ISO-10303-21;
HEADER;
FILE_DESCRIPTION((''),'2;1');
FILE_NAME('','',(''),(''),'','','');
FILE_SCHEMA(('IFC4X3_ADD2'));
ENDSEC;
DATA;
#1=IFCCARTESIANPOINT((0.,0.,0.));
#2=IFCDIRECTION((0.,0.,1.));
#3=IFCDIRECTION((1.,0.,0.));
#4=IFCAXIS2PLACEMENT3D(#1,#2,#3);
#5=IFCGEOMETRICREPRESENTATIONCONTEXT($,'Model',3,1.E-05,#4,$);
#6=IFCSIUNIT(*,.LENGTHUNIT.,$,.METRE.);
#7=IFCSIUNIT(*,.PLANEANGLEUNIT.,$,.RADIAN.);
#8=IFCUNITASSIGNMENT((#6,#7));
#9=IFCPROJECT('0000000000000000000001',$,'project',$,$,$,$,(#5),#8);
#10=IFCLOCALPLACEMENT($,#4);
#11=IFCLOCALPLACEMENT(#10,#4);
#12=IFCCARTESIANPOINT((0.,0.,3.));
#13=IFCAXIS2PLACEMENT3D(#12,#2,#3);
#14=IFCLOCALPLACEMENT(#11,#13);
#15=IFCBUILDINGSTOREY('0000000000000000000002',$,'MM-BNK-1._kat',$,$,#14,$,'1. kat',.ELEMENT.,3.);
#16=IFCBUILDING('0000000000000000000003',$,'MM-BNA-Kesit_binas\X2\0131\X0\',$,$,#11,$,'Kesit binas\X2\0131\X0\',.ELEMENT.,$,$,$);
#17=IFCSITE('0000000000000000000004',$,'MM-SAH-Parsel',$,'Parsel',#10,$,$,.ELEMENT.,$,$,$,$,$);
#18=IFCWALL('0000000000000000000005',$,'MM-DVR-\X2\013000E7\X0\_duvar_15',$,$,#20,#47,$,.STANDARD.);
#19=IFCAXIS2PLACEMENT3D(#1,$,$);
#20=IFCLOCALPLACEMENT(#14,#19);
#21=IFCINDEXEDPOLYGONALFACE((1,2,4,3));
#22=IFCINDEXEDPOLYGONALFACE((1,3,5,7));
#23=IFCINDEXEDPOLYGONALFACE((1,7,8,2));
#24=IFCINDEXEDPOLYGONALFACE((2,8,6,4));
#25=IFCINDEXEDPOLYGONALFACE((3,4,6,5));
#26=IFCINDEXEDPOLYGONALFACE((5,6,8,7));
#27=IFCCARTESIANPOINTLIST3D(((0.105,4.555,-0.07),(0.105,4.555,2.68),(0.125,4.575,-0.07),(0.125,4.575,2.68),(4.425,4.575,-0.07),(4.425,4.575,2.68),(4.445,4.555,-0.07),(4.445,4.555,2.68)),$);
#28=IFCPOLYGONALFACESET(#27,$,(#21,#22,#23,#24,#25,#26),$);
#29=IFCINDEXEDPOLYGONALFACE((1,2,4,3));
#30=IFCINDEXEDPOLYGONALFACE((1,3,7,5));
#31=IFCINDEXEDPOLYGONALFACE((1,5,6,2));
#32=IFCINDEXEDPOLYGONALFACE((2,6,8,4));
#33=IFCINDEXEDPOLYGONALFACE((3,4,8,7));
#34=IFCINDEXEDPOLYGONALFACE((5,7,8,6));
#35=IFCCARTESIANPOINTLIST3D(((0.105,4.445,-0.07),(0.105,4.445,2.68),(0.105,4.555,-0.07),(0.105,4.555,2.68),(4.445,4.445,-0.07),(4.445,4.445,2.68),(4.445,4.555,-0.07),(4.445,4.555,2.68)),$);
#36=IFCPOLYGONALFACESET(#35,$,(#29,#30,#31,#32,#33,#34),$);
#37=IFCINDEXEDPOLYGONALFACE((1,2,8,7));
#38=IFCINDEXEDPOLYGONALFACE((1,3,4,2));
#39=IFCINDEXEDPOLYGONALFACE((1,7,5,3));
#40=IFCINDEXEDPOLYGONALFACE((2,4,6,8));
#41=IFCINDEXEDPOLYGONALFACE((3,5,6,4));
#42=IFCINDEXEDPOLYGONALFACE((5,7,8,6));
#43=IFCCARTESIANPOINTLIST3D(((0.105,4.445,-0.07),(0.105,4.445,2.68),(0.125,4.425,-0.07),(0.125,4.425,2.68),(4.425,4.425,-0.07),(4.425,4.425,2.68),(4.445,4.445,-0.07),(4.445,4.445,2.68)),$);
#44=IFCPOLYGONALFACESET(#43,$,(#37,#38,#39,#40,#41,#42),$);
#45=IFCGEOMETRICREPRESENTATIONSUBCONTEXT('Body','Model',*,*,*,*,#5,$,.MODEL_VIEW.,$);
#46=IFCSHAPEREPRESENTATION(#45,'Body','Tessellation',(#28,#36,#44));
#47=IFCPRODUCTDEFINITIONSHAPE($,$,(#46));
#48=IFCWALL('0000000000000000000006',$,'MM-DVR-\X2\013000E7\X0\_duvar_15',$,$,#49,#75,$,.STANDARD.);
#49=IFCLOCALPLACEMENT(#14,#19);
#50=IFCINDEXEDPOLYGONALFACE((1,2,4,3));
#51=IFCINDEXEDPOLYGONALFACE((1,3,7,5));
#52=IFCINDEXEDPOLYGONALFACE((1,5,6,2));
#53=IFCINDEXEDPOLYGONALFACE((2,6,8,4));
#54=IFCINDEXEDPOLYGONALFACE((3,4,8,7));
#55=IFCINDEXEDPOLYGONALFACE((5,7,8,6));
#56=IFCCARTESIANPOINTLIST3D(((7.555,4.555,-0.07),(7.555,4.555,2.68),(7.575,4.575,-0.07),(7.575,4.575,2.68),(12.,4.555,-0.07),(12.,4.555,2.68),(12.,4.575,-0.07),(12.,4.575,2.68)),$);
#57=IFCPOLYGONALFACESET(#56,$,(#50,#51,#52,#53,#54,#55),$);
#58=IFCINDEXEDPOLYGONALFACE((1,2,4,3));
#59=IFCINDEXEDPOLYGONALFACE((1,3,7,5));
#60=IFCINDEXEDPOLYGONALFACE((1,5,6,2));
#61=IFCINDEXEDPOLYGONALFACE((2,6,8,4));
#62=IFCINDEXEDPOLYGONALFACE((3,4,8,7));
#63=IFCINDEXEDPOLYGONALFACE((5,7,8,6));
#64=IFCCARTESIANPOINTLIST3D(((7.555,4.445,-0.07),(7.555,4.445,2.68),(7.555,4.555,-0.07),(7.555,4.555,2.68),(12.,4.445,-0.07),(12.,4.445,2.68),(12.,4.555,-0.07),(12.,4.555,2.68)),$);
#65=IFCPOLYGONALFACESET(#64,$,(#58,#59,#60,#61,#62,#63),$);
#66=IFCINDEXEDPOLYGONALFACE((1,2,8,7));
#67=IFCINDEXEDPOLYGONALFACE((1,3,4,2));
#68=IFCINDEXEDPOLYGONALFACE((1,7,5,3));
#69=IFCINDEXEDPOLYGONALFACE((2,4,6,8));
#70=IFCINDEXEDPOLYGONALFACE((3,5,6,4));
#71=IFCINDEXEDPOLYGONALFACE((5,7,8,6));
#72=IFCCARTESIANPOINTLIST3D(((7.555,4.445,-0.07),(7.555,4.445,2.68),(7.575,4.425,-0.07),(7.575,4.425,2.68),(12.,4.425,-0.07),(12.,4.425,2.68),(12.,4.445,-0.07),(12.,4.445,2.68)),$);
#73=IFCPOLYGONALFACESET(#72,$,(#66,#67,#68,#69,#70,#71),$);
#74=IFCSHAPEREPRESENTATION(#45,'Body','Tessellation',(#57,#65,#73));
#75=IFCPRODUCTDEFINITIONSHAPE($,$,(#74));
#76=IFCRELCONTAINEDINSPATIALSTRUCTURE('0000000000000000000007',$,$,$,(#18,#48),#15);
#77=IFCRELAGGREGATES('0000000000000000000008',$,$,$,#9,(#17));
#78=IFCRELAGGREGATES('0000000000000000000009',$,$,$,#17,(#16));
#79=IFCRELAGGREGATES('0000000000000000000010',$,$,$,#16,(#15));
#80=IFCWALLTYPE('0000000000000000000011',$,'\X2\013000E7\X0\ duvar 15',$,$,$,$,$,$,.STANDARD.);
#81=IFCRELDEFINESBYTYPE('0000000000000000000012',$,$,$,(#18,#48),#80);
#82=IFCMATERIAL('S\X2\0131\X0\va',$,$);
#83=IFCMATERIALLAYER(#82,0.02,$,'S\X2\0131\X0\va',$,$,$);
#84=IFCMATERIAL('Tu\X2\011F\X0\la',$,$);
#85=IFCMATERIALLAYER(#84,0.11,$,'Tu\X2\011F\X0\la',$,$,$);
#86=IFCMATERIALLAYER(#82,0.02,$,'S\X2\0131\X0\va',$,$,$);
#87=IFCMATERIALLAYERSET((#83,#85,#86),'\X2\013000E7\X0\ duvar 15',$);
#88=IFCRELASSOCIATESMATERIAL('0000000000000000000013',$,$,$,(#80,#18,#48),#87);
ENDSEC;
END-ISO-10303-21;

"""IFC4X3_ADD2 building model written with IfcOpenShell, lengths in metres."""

from ifc_helpers import new_model, si_unit, frame, origin_with_axes, place, context, subcontext, project, spatial, polyline, outline, extrude, material, layer, layer_set, type_object, element, save


model = new_model("IFC4X3_ADD2")

# Units and contexts
model_context = context("Model", 3, precision=1e-05, world=origin_with_axes())
body_context = subcontext(model_context, "Body", "Model", "MODEL_VIEW")
ifc_project = project(units=[si_unit("LENGTHUNIT", "METRE"), si_unit("PLANEANGLEUNIT", "RADIAN")], contexts=[model_context])

# Site, building, storey
site_placement = place(None, origin_with_axes())
site = spatial("IfcSite", under=ifc_project, at=site_placement, Name="MM-SAH-Parsel", ObjectType="Parsel", CompositionType="ELEMENT")
building_placement = place(site_placement, origin_with_axes())
building = spatial("IfcBuilding", under=site, at=building_placement, Name="MM-BNA-Kesit_binası", LongName="Kesit binası", CompositionType="ELEMENT")
storey_placement = place(building_placement, frame((0.0, 0.0, 3.0), z_axis=(0.0, 0.0, 1.0), x_axis=(1.0, 0.0, 0.0)))
storey = spatial("IfcBuildingStorey", under=building, at=storey_placement, Name="MM-BNK-1._kat", LongName="1. kat", CompositionType="ELEMENT", Elevation=3.0)

# Shared definitions
ifc_material_1 = material(Name="Tuğla")

# Shared definitions
ifc_material_2 = material(Name="Sıva")
ifc_layer_1 = layer(ifc_material_2, 0.02, Name="Sıva")
ifc_layer_2 = layer(ifc_material_1, 0.11, Name="Tuğla")
ifc_layer_3 = layer(ifc_material_2, 0.02, Name="Sıva")
ifc_layer_set_1 = layer_set([ifc_layer_1, ifc_layer_2, ifc_layer_3], Name="İç duvar 15")
wall_type_1 = type_object("IfcWallType", Name="İç duvar 15", PredefinedType="STANDARD", material=ifc_layer_set_1)

# Walls
wall_1_placement = place(storey_placement, origin_with_axes())
element("IfcWall", 1, at=wall_1_placement, inside=storey, type_object=wall_type_1, material=ifc_layer_set_1, Name="MM-DVR-İç_duvar_15", PredefinedType="STANDARD", context=body_context, shape_type="SweptSolid", body=[
    extrude(outline(polyline([(0.125, 4.575), (4.425, 4.575), (4.445, 4.555), (0.105, 4.555), (0.125, 4.575)])), frame((0.0, 0.0, -0.07)), (0.0, 0.0, 1.0), 2.75),
    extrude(outline(polyline([(0.105, 4.555), (4.445, 4.555), (4.445, 4.445), (0.105, 4.445), (0.105, 4.555)])), frame((0.0, 0.0, -0.07)), (0.0, 0.0, 1.0), 2.75),
    extrude(outline(polyline([(0.105, 4.445), (4.445, 4.445), (4.425, 4.425), (0.125, 4.425), (0.105, 4.445)])), frame((0.0, 0.0, -0.07)), (0.0, 0.0, 1.0), 2.75),
])
wall_2_placement = place(storey_placement, origin_with_axes())
element("IfcWall", 2, at=wall_2_placement, inside=storey, type_object=wall_type_1, material=ifc_layer_set_1, Name="MM-DVR-İç_duvar_15", PredefinedType="STANDARD", context=body_context, shape_type="SweptSolid", body=[
    extrude(outline(polyline([(7.575, 4.575), (12.0, 4.575), (12.0, 4.555), (7.555, 4.555), (7.575, 4.575)])), frame((0.0, 0.0, -0.07)), (0.0, 0.0, 1.0), 2.75),
    extrude(outline(polyline([(7.555, 4.555), (12.0, 4.555), (12.0, 4.445), (7.555, 4.445), (7.555, 4.555)])), frame((0.0, 0.0, -0.07)), (0.0, 0.0, 1.0), 2.75),
    extrude(outline(polyline([(7.555, 4.445), (12.0, 4.445), (12.0, 4.425), (7.575, 4.425), (7.555, 4.445)])), frame((0.0, 0.0, -0.07)), (0.0, 0.0, 1.0), 2.75),
])

save(model, "model.ifc")
